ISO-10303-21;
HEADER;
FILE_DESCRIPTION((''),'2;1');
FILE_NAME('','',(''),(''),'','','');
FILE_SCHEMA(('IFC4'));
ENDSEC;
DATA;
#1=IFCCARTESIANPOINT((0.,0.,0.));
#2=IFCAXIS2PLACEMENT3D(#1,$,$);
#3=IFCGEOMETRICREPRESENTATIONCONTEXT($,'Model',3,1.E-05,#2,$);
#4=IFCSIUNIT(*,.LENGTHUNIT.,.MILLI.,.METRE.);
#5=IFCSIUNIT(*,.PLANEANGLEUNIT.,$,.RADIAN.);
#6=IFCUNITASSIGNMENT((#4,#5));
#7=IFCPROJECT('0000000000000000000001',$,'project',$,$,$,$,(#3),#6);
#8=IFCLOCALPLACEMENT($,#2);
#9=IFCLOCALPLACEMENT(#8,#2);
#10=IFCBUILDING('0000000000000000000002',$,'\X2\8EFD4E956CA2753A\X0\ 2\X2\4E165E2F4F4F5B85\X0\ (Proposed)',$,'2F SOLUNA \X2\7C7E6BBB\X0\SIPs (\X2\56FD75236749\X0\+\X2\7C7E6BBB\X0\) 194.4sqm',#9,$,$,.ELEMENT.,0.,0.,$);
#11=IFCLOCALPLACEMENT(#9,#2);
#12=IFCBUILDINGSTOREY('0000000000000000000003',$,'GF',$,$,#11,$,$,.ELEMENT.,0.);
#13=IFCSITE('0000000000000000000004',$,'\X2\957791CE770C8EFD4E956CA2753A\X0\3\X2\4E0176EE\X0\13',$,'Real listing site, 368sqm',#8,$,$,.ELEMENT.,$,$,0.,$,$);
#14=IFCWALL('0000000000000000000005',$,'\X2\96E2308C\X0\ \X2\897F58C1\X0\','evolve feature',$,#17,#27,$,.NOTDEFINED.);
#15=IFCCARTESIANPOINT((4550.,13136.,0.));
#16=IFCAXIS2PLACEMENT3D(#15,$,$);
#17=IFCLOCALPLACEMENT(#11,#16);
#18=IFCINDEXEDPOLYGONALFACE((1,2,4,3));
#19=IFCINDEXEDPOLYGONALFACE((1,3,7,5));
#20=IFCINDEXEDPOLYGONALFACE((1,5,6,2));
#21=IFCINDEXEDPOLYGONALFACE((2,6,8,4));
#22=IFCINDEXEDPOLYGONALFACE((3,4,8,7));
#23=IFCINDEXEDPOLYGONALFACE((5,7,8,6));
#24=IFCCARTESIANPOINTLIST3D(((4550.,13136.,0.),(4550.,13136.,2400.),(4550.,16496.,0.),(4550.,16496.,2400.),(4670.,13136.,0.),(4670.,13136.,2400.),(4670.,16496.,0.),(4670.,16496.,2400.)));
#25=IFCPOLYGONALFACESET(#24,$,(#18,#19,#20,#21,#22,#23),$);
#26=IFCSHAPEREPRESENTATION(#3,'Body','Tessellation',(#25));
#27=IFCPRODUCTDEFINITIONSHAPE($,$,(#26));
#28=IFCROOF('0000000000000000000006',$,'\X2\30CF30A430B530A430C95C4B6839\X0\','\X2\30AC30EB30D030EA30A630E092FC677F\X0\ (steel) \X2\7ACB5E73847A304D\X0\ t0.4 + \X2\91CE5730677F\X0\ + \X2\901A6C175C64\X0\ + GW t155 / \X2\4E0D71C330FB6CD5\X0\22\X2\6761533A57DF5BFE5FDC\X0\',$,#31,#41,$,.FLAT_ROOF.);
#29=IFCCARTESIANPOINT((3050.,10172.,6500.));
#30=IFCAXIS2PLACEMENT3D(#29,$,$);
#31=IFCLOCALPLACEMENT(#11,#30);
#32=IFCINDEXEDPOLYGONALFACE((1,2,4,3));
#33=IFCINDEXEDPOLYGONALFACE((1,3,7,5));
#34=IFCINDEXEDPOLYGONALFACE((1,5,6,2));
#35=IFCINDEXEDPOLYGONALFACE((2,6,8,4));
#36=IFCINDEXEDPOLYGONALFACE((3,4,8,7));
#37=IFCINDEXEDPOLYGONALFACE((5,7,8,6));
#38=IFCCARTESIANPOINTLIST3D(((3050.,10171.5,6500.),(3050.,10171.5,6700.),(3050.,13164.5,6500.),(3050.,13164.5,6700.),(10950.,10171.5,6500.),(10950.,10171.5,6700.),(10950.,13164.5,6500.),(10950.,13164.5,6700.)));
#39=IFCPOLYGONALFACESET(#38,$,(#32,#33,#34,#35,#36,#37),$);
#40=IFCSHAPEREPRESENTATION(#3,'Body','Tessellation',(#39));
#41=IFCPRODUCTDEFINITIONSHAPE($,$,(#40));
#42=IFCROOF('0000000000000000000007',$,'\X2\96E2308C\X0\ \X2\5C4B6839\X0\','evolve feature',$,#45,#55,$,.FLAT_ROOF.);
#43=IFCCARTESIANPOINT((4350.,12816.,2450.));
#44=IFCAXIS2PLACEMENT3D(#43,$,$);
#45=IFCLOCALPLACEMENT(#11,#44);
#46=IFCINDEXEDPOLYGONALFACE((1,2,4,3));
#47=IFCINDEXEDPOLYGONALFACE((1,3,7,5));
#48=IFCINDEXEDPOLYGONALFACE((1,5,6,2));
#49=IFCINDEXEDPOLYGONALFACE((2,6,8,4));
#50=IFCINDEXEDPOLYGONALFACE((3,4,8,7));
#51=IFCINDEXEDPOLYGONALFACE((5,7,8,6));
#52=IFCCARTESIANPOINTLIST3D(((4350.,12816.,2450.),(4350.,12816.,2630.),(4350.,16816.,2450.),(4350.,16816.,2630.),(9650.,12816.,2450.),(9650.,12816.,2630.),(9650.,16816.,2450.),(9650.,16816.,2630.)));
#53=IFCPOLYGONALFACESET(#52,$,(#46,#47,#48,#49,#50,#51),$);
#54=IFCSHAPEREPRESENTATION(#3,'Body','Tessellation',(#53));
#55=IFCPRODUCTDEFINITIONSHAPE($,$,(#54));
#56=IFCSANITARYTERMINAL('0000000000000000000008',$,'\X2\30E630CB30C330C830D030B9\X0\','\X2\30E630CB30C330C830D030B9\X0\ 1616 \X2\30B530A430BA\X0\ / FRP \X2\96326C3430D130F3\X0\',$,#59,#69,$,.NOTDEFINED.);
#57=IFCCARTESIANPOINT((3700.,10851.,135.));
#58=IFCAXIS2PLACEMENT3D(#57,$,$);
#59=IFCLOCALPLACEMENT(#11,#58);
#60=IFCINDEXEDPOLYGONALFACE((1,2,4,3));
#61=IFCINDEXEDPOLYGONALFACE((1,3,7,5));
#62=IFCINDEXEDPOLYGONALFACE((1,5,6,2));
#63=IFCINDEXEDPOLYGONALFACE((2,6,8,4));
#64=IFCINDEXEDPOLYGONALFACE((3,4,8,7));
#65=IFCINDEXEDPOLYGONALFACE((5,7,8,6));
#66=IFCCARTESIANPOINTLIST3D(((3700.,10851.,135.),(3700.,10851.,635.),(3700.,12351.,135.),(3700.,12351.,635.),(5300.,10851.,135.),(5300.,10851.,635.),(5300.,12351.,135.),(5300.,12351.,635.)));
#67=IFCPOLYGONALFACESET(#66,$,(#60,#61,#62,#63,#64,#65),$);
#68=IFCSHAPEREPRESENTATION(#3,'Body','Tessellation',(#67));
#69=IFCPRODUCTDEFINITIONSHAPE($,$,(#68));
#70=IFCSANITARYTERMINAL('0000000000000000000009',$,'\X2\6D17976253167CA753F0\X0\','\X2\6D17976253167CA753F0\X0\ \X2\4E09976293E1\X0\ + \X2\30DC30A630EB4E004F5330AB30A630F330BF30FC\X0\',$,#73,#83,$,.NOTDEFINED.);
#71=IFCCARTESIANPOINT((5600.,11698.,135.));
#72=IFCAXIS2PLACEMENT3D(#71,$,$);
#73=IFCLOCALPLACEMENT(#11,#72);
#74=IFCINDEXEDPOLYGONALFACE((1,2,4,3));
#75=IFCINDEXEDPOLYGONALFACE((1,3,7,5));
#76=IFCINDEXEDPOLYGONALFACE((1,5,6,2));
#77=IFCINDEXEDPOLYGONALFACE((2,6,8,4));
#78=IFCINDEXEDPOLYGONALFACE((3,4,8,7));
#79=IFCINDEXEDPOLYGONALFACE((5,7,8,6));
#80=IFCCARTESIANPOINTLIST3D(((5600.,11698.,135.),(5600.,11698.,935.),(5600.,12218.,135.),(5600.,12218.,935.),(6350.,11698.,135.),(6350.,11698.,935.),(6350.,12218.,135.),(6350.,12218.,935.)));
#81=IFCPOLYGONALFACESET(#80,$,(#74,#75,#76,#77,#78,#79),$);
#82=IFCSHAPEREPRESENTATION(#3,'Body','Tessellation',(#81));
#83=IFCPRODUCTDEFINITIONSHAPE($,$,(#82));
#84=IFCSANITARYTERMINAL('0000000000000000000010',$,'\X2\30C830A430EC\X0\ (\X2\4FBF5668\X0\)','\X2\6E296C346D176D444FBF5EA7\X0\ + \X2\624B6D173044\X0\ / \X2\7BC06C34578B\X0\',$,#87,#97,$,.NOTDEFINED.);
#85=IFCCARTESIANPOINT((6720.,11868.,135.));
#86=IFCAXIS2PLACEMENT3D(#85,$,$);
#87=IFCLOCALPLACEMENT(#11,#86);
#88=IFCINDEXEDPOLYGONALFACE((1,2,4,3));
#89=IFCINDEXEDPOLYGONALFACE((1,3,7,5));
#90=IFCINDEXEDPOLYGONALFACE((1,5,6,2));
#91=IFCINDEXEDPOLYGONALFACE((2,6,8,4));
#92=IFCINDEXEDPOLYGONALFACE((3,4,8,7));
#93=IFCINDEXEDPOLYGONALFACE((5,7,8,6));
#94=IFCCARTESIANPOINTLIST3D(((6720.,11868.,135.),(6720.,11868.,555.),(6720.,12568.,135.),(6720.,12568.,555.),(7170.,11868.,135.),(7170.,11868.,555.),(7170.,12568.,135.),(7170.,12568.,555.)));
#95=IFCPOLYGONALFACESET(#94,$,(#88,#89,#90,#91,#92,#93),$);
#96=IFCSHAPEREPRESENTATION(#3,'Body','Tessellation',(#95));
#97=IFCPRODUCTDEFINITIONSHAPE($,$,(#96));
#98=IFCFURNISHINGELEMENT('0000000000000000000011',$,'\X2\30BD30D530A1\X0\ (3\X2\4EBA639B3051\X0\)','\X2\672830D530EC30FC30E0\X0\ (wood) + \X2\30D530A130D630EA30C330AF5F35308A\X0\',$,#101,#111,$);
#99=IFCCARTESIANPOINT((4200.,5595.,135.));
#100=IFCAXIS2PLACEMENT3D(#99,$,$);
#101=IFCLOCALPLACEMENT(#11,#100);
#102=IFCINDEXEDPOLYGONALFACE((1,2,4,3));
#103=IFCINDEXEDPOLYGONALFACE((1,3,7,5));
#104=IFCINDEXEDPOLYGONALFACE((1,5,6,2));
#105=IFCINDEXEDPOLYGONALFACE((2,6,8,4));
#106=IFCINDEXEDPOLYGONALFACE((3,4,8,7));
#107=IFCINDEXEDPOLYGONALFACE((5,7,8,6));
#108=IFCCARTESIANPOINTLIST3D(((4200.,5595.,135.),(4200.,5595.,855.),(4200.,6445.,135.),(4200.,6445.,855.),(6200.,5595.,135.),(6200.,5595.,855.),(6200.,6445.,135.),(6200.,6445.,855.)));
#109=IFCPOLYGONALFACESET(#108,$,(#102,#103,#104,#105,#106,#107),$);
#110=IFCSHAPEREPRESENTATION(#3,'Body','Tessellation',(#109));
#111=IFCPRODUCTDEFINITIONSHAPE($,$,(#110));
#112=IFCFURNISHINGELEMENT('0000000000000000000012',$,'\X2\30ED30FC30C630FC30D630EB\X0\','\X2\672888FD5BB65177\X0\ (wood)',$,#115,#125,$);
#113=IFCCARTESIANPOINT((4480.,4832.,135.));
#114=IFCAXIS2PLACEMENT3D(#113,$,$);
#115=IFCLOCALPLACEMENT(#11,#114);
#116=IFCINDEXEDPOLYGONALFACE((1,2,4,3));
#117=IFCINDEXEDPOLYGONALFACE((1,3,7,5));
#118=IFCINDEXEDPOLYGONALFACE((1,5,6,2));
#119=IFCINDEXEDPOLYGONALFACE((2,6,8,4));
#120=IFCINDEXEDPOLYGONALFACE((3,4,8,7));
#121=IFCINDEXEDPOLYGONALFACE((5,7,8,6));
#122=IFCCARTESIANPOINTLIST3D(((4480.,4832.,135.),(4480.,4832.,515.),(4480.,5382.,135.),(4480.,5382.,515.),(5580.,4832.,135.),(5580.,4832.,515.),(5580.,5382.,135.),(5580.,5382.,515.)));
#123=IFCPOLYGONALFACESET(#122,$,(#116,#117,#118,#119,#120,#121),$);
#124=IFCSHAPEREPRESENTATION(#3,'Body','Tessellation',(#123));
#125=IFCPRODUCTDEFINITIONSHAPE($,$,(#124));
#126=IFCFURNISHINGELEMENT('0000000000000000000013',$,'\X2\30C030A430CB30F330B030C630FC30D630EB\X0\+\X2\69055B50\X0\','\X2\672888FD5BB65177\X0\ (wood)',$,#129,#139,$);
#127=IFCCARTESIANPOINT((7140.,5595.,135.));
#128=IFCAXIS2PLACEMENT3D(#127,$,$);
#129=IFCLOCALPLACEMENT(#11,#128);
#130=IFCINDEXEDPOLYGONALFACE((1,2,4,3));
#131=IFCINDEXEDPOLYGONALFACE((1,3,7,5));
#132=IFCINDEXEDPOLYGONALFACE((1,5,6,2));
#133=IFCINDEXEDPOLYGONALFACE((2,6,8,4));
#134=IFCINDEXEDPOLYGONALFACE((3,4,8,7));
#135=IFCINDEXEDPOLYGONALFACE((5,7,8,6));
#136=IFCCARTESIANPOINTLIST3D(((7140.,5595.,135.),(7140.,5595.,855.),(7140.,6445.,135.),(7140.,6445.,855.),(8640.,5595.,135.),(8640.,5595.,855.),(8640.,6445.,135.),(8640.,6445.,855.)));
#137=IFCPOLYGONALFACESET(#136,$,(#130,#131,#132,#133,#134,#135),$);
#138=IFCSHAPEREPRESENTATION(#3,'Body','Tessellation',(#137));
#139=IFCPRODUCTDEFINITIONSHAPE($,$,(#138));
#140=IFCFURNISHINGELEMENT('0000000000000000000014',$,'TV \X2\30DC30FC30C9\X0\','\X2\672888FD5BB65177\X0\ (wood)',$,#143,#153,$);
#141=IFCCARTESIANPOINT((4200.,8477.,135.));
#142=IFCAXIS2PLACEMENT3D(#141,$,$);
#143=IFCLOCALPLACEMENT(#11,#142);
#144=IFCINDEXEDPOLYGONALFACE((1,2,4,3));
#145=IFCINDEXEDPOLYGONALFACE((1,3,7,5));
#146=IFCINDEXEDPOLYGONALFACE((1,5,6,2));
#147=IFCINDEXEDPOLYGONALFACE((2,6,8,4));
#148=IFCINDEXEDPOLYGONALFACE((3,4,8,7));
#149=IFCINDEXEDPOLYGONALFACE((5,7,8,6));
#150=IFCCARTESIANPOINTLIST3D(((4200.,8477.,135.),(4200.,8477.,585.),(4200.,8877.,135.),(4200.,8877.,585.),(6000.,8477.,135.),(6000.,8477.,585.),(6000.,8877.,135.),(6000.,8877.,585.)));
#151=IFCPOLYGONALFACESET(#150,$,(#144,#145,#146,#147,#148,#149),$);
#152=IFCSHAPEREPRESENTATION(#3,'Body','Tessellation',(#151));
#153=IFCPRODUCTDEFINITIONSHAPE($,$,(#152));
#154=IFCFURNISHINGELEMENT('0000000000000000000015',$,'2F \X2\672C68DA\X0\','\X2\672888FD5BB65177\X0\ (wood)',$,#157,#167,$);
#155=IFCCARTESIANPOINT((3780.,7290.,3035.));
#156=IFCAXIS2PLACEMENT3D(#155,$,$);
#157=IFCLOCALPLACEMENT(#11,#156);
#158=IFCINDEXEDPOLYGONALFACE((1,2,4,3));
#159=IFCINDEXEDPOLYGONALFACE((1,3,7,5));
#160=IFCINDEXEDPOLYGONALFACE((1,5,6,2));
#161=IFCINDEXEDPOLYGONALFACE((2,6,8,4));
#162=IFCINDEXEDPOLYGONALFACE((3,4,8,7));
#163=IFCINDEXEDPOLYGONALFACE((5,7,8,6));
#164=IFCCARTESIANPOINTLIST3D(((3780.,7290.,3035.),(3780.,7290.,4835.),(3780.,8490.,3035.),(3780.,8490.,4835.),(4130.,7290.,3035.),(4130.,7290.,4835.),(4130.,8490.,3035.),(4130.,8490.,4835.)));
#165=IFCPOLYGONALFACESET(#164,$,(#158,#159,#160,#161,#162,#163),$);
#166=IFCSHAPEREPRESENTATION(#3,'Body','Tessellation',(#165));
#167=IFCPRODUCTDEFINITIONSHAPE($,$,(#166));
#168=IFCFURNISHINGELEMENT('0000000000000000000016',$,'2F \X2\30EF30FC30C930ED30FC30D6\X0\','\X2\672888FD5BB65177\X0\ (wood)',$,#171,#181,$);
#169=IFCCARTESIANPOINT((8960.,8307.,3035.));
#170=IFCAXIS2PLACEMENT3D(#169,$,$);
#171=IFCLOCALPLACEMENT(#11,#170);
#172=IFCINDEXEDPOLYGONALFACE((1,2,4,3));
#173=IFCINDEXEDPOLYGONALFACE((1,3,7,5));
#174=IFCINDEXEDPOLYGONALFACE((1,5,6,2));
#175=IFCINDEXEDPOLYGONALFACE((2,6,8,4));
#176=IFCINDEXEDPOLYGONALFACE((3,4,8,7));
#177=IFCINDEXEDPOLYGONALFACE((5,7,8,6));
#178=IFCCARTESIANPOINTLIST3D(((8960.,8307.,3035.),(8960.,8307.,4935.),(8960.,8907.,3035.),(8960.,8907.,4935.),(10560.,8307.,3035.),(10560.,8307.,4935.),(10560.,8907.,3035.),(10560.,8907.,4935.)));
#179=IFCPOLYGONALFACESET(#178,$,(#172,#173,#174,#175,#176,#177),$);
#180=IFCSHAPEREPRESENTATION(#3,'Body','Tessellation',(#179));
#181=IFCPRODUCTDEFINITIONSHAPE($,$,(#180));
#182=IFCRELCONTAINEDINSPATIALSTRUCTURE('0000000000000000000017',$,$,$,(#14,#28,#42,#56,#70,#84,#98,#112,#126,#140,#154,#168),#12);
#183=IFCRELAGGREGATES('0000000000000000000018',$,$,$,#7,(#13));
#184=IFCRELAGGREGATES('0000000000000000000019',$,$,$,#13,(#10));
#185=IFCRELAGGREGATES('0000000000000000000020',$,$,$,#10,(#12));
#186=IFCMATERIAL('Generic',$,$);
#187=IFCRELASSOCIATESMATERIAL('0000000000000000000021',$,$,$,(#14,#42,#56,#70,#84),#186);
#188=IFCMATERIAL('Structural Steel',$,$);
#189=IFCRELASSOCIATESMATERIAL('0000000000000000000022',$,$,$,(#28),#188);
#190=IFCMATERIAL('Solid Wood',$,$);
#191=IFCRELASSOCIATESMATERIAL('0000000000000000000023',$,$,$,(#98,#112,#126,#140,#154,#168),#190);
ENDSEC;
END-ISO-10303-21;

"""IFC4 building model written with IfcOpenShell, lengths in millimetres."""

from ifc_helpers import new_model, si_unit, frame, frame_2d, origin, place, context, project, spatial, rectangle, extrude, material, element, save


model = new_model("IFC4")

# Units and contexts
model_context = context("Model", 3, precision=1e-05, world=origin())
ifc_project = project(units=[si_unit("LENGTHUNIT", "METRE", prefix="MILLI"), si_unit("PLANEANGLEUNIT", "RADIAN")], contexts=[model_context])

# Site, building, storey
site_placement = place(None, origin())
site = spatial("IfcSite", under=ifc_project, at=site_placement, Name="長野県軽井沢町3丁目13", ObjectType="Real listing site, 368sqm", CompositionType="ELEMENT", RefElevation=0.0)
building_placement = place(site_placement, origin())
building = spatial("IfcBuilding", under=site, at=building_placement, Name="軽井沢町 2世帯住宅 (Proposed)", ObjectType="2F SOLUNA 籾殻SIPs (国産杉+籾殻) 194.4sqm", CompositionType="ELEMENT", ElevationOfRefHeight=0.0, ElevationOfTerrain=0.0)
storey_placement = place(building_placement, origin())
storey = spatial("IfcBuildingStorey", under=building, at=storey_placement, Name="GF", CompositionType="ELEMENT", Elevation=0.0)

# Shared definitions
ifc_material_1 = material(Name="Generic")

# Shared definitions
ifc_material_2 = material(Name="Solid Wood")

# Wall
wall_1_placement = place(storey_placement, frame((4550.0, 13136.0, 0.0)))
element("IfcWall", 1, at=wall_1_placement, inside=storey, material=ifc_material_1, Name="離れ 西壁", Description="evolve feature", PredefinedType="NOTDEFINED", context=model_context, shape_type="SweptSolid", body=[
    extrude(rectangle(XDim=120.0, YDim=3360.0, at=frame_2d((60.0, 1680.0))), frame((4550.0, 13136.0, 0.0)), (0.0, 0.0, 1.0), 2400.0),
])

# Roofs
ifc_material_3 = material(Name="Structural Steel")
roof_1_placement = place(storey_placement, frame((3050.0, 10172.0, 6500.0)))
element("IfcRoof", 2, at=roof_1_placement, inside=storey, material=ifc_material_3, Name="ハイサイド屋根", Description="ガルバリウム鋼板 (steel) 立平葺き t0.4 + 野地板 + 通気層 + GW t155 / 不燃・法22条区域対応", PredefinedType="FLAT_ROOF", context=model_context, shape_type="SweptSolid", body=[
    extrude(rectangle(XDim=7900.0, YDim=2993.0, at=frame_2d((3950.0, 1496.0))), frame((3050.0, 10172.0, 6500.0)), (0.0, 0.0, 1.0), 200.0),
])
roof_2_placement = place(storey_placement, frame((4350.0, 12816.0, 2450.0)))
element("IfcRoof", 3, at=roof_2_placement, inside=storey, material=ifc_material_1, Name="離れ 屋根", Description="evolve feature", PredefinedType="FLAT_ROOF", context=model_context, shape_type="SweptSolid", body=[
    extrude(rectangle(XDim=5300.0, YDim=4000.0, at=frame_2d((2650.0, 2000.0))), frame((4350.0, 12816.0, 2450.0)), (0.0, 0.0, 1.0), 180.0),
])

# Sanitary terminals
sanitary_terminal_1_placement = place(storey_placement, frame((3700.0, 10851.0, 135.0)))
element("IfcSanitaryTerminal", 4, at=sanitary_terminal_1_placement, inside=storey, material=ifc_material_1, Name="ユニットバス", Description="ユニットバス 1616 サイズ / FRP 防水パン", PredefinedType="NOTDEFINED", context=model_context, shape_type="SweptSolid", body=[
    extrude(rectangle(XDim=1600.0, YDim=1500.0, at=frame_2d((800.0, 750.0))), frame((3700.0, 10851.0, 135.0)), (0.0, 0.0, 1.0), 500.0),
])
sanitary_terminal_2_placement = place(storey_placement, frame((5600.0, 11698.0, 135.0)))
element("IfcSanitaryTerminal", 5, at=sanitary_terminal_2_placement, inside=storey, material=ifc_material_1, Name="洗面化粧台", Description="洗面化粧台 三面鏡 + ボウル一体カウンター", PredefinedType="NOTDEFINED", context=model_context, shape_type="SweptSolid", body=[
    extrude(rectangle(XDim=750.0, YDim=520.0, at=frame_2d((375.0, 260.0))), frame((5600.0, 11698.0, 135.0)), (0.0, 0.0, 1.0), 800.0),
])
sanitary_terminal_3_placement = place(storey_placement, frame((6720.0, 11868.0, 135.0)))
element("IfcSanitaryTerminal", 6, at=sanitary_terminal_3_placement, inside=storey, material=ifc_material_1, Name="トイレ (便器)", Description="温水洗浄便座 + 手洗い / 節水型", PredefinedType="NOTDEFINED", context=model_context, shape_type="SweptSolid", body=[
    extrude(rectangle(XDim=450.0, YDim=700.0, at=frame_2d((225.0, 350.0))), frame((6720.0, 11868.0, 135.0)), (0.0, 0.0, 1.0), 420.0),
])

# Furnishing elements
furnishing_1_placement = place(storey_placement, frame((4200.0, 5595.0, 135.0)))
element("IfcFurnishingElement", 7, at=furnishing_1_placement, inside=storey, material=ifc_material_2, Name="ソファ (3人掛け)", Description="木フレーム (wood) + ファブリック張り", context=model_context, shape_type="SweptSolid", body=[
    extrude(rectangle(XDim=2000.0, YDim=850.0, at=frame_2d((1000.0, 425.0))), frame((4200.0, 5595.0, 135.0)), (0.0, 0.0, 1.0), 720.0),
])
furnishing_2_placement = place(storey_placement, frame((4480.0, 4832.0, 135.0)))
element("IfcFurnishingElement", 8, at=furnishing_2_placement, inside=storey, material=ifc_material_2, Name="ローテーブル", Description="木製家具 (wood)", context=model_context, shape_type="SweptSolid", body=[
    extrude(rectangle(XDim=1100.0, YDim=550.0, at=frame_2d((550.0, 275.0))), frame((4480.0, 4832.0, 135.0)), (0.0, 0.0, 1.0), 380.0),
])
furnishing_3_placement = place(storey_placement, frame((7140.0, 5595.0, 135.0)))
element("IfcFurnishingElement", 9, at=furnishing_3_placement, inside=storey, material=ifc_material_2, Name="ダイニングテーブル+椅子", Description="木製家具 (wood)", context=model_context, shape_type="SweptSolid", body=[
    extrude(rectangle(XDim=1500.0, YDim=850.0, at=frame_2d((750.0, 425.0))), frame((7140.0, 5595.0, 135.0)), (0.0, 0.0, 1.0), 720.0),
])
furnishing_4_placement = place(storey_placement, frame((4200.0, 8477.0, 135.0)))
element("IfcFurnishingElement", 10, at=furnishing_4_placement, inside=storey, material=ifc_material_2, Name="TV ボード", Description="木製家具 (wood)", context=model_context, shape_type="SweptSolid", body=[
    extrude(rectangle(XDim=1800.0, YDim=400.0, at=frame_2d((900.0, 200.0))), frame((4200.0, 8477.0, 135.0)), (0.0, 0.0, 1.0), 450.0),
])
furnishing_5_placement = place(storey_placement, frame((3780.0, 7290.0, 3035.0)))
element("IfcFurnishingElement", 11, at=furnishing_5_placement, inside=storey, material=ifc_material_2, Name="2F 本棚", Description="木製家具 (wood)", context=model_context, shape_type="SweptSolid", body=[
    extrude(rectangle(XDim=350.0, YDim=1200.0, at=frame_2d((175.0, 600.0))), frame((3780.0, 7290.0, 3035.0)), (0.0, 0.0, 1.0), 1800.0),
])
furnishing_6_placement = place(storey_placement, frame((8960.0, 8307.0, 3035.0)))
element("IfcFurnishingElement", 12, at=furnishing_6_placement, inside=storey, material=ifc_material_2, Name="2F ワードローブ", Description="木製家具 (wood)", context=model_context, shape_type="SweptSolid", body=[
    extrude(rectangle(XDim=1600.0, YDim=600.0, at=frame_2d((800.0, 300.0))), frame((8960.0, 8307.0, 3035.0)), (0.0, 0.0, 1.0), 1900.0),
])

save(model, "model.ifc")
